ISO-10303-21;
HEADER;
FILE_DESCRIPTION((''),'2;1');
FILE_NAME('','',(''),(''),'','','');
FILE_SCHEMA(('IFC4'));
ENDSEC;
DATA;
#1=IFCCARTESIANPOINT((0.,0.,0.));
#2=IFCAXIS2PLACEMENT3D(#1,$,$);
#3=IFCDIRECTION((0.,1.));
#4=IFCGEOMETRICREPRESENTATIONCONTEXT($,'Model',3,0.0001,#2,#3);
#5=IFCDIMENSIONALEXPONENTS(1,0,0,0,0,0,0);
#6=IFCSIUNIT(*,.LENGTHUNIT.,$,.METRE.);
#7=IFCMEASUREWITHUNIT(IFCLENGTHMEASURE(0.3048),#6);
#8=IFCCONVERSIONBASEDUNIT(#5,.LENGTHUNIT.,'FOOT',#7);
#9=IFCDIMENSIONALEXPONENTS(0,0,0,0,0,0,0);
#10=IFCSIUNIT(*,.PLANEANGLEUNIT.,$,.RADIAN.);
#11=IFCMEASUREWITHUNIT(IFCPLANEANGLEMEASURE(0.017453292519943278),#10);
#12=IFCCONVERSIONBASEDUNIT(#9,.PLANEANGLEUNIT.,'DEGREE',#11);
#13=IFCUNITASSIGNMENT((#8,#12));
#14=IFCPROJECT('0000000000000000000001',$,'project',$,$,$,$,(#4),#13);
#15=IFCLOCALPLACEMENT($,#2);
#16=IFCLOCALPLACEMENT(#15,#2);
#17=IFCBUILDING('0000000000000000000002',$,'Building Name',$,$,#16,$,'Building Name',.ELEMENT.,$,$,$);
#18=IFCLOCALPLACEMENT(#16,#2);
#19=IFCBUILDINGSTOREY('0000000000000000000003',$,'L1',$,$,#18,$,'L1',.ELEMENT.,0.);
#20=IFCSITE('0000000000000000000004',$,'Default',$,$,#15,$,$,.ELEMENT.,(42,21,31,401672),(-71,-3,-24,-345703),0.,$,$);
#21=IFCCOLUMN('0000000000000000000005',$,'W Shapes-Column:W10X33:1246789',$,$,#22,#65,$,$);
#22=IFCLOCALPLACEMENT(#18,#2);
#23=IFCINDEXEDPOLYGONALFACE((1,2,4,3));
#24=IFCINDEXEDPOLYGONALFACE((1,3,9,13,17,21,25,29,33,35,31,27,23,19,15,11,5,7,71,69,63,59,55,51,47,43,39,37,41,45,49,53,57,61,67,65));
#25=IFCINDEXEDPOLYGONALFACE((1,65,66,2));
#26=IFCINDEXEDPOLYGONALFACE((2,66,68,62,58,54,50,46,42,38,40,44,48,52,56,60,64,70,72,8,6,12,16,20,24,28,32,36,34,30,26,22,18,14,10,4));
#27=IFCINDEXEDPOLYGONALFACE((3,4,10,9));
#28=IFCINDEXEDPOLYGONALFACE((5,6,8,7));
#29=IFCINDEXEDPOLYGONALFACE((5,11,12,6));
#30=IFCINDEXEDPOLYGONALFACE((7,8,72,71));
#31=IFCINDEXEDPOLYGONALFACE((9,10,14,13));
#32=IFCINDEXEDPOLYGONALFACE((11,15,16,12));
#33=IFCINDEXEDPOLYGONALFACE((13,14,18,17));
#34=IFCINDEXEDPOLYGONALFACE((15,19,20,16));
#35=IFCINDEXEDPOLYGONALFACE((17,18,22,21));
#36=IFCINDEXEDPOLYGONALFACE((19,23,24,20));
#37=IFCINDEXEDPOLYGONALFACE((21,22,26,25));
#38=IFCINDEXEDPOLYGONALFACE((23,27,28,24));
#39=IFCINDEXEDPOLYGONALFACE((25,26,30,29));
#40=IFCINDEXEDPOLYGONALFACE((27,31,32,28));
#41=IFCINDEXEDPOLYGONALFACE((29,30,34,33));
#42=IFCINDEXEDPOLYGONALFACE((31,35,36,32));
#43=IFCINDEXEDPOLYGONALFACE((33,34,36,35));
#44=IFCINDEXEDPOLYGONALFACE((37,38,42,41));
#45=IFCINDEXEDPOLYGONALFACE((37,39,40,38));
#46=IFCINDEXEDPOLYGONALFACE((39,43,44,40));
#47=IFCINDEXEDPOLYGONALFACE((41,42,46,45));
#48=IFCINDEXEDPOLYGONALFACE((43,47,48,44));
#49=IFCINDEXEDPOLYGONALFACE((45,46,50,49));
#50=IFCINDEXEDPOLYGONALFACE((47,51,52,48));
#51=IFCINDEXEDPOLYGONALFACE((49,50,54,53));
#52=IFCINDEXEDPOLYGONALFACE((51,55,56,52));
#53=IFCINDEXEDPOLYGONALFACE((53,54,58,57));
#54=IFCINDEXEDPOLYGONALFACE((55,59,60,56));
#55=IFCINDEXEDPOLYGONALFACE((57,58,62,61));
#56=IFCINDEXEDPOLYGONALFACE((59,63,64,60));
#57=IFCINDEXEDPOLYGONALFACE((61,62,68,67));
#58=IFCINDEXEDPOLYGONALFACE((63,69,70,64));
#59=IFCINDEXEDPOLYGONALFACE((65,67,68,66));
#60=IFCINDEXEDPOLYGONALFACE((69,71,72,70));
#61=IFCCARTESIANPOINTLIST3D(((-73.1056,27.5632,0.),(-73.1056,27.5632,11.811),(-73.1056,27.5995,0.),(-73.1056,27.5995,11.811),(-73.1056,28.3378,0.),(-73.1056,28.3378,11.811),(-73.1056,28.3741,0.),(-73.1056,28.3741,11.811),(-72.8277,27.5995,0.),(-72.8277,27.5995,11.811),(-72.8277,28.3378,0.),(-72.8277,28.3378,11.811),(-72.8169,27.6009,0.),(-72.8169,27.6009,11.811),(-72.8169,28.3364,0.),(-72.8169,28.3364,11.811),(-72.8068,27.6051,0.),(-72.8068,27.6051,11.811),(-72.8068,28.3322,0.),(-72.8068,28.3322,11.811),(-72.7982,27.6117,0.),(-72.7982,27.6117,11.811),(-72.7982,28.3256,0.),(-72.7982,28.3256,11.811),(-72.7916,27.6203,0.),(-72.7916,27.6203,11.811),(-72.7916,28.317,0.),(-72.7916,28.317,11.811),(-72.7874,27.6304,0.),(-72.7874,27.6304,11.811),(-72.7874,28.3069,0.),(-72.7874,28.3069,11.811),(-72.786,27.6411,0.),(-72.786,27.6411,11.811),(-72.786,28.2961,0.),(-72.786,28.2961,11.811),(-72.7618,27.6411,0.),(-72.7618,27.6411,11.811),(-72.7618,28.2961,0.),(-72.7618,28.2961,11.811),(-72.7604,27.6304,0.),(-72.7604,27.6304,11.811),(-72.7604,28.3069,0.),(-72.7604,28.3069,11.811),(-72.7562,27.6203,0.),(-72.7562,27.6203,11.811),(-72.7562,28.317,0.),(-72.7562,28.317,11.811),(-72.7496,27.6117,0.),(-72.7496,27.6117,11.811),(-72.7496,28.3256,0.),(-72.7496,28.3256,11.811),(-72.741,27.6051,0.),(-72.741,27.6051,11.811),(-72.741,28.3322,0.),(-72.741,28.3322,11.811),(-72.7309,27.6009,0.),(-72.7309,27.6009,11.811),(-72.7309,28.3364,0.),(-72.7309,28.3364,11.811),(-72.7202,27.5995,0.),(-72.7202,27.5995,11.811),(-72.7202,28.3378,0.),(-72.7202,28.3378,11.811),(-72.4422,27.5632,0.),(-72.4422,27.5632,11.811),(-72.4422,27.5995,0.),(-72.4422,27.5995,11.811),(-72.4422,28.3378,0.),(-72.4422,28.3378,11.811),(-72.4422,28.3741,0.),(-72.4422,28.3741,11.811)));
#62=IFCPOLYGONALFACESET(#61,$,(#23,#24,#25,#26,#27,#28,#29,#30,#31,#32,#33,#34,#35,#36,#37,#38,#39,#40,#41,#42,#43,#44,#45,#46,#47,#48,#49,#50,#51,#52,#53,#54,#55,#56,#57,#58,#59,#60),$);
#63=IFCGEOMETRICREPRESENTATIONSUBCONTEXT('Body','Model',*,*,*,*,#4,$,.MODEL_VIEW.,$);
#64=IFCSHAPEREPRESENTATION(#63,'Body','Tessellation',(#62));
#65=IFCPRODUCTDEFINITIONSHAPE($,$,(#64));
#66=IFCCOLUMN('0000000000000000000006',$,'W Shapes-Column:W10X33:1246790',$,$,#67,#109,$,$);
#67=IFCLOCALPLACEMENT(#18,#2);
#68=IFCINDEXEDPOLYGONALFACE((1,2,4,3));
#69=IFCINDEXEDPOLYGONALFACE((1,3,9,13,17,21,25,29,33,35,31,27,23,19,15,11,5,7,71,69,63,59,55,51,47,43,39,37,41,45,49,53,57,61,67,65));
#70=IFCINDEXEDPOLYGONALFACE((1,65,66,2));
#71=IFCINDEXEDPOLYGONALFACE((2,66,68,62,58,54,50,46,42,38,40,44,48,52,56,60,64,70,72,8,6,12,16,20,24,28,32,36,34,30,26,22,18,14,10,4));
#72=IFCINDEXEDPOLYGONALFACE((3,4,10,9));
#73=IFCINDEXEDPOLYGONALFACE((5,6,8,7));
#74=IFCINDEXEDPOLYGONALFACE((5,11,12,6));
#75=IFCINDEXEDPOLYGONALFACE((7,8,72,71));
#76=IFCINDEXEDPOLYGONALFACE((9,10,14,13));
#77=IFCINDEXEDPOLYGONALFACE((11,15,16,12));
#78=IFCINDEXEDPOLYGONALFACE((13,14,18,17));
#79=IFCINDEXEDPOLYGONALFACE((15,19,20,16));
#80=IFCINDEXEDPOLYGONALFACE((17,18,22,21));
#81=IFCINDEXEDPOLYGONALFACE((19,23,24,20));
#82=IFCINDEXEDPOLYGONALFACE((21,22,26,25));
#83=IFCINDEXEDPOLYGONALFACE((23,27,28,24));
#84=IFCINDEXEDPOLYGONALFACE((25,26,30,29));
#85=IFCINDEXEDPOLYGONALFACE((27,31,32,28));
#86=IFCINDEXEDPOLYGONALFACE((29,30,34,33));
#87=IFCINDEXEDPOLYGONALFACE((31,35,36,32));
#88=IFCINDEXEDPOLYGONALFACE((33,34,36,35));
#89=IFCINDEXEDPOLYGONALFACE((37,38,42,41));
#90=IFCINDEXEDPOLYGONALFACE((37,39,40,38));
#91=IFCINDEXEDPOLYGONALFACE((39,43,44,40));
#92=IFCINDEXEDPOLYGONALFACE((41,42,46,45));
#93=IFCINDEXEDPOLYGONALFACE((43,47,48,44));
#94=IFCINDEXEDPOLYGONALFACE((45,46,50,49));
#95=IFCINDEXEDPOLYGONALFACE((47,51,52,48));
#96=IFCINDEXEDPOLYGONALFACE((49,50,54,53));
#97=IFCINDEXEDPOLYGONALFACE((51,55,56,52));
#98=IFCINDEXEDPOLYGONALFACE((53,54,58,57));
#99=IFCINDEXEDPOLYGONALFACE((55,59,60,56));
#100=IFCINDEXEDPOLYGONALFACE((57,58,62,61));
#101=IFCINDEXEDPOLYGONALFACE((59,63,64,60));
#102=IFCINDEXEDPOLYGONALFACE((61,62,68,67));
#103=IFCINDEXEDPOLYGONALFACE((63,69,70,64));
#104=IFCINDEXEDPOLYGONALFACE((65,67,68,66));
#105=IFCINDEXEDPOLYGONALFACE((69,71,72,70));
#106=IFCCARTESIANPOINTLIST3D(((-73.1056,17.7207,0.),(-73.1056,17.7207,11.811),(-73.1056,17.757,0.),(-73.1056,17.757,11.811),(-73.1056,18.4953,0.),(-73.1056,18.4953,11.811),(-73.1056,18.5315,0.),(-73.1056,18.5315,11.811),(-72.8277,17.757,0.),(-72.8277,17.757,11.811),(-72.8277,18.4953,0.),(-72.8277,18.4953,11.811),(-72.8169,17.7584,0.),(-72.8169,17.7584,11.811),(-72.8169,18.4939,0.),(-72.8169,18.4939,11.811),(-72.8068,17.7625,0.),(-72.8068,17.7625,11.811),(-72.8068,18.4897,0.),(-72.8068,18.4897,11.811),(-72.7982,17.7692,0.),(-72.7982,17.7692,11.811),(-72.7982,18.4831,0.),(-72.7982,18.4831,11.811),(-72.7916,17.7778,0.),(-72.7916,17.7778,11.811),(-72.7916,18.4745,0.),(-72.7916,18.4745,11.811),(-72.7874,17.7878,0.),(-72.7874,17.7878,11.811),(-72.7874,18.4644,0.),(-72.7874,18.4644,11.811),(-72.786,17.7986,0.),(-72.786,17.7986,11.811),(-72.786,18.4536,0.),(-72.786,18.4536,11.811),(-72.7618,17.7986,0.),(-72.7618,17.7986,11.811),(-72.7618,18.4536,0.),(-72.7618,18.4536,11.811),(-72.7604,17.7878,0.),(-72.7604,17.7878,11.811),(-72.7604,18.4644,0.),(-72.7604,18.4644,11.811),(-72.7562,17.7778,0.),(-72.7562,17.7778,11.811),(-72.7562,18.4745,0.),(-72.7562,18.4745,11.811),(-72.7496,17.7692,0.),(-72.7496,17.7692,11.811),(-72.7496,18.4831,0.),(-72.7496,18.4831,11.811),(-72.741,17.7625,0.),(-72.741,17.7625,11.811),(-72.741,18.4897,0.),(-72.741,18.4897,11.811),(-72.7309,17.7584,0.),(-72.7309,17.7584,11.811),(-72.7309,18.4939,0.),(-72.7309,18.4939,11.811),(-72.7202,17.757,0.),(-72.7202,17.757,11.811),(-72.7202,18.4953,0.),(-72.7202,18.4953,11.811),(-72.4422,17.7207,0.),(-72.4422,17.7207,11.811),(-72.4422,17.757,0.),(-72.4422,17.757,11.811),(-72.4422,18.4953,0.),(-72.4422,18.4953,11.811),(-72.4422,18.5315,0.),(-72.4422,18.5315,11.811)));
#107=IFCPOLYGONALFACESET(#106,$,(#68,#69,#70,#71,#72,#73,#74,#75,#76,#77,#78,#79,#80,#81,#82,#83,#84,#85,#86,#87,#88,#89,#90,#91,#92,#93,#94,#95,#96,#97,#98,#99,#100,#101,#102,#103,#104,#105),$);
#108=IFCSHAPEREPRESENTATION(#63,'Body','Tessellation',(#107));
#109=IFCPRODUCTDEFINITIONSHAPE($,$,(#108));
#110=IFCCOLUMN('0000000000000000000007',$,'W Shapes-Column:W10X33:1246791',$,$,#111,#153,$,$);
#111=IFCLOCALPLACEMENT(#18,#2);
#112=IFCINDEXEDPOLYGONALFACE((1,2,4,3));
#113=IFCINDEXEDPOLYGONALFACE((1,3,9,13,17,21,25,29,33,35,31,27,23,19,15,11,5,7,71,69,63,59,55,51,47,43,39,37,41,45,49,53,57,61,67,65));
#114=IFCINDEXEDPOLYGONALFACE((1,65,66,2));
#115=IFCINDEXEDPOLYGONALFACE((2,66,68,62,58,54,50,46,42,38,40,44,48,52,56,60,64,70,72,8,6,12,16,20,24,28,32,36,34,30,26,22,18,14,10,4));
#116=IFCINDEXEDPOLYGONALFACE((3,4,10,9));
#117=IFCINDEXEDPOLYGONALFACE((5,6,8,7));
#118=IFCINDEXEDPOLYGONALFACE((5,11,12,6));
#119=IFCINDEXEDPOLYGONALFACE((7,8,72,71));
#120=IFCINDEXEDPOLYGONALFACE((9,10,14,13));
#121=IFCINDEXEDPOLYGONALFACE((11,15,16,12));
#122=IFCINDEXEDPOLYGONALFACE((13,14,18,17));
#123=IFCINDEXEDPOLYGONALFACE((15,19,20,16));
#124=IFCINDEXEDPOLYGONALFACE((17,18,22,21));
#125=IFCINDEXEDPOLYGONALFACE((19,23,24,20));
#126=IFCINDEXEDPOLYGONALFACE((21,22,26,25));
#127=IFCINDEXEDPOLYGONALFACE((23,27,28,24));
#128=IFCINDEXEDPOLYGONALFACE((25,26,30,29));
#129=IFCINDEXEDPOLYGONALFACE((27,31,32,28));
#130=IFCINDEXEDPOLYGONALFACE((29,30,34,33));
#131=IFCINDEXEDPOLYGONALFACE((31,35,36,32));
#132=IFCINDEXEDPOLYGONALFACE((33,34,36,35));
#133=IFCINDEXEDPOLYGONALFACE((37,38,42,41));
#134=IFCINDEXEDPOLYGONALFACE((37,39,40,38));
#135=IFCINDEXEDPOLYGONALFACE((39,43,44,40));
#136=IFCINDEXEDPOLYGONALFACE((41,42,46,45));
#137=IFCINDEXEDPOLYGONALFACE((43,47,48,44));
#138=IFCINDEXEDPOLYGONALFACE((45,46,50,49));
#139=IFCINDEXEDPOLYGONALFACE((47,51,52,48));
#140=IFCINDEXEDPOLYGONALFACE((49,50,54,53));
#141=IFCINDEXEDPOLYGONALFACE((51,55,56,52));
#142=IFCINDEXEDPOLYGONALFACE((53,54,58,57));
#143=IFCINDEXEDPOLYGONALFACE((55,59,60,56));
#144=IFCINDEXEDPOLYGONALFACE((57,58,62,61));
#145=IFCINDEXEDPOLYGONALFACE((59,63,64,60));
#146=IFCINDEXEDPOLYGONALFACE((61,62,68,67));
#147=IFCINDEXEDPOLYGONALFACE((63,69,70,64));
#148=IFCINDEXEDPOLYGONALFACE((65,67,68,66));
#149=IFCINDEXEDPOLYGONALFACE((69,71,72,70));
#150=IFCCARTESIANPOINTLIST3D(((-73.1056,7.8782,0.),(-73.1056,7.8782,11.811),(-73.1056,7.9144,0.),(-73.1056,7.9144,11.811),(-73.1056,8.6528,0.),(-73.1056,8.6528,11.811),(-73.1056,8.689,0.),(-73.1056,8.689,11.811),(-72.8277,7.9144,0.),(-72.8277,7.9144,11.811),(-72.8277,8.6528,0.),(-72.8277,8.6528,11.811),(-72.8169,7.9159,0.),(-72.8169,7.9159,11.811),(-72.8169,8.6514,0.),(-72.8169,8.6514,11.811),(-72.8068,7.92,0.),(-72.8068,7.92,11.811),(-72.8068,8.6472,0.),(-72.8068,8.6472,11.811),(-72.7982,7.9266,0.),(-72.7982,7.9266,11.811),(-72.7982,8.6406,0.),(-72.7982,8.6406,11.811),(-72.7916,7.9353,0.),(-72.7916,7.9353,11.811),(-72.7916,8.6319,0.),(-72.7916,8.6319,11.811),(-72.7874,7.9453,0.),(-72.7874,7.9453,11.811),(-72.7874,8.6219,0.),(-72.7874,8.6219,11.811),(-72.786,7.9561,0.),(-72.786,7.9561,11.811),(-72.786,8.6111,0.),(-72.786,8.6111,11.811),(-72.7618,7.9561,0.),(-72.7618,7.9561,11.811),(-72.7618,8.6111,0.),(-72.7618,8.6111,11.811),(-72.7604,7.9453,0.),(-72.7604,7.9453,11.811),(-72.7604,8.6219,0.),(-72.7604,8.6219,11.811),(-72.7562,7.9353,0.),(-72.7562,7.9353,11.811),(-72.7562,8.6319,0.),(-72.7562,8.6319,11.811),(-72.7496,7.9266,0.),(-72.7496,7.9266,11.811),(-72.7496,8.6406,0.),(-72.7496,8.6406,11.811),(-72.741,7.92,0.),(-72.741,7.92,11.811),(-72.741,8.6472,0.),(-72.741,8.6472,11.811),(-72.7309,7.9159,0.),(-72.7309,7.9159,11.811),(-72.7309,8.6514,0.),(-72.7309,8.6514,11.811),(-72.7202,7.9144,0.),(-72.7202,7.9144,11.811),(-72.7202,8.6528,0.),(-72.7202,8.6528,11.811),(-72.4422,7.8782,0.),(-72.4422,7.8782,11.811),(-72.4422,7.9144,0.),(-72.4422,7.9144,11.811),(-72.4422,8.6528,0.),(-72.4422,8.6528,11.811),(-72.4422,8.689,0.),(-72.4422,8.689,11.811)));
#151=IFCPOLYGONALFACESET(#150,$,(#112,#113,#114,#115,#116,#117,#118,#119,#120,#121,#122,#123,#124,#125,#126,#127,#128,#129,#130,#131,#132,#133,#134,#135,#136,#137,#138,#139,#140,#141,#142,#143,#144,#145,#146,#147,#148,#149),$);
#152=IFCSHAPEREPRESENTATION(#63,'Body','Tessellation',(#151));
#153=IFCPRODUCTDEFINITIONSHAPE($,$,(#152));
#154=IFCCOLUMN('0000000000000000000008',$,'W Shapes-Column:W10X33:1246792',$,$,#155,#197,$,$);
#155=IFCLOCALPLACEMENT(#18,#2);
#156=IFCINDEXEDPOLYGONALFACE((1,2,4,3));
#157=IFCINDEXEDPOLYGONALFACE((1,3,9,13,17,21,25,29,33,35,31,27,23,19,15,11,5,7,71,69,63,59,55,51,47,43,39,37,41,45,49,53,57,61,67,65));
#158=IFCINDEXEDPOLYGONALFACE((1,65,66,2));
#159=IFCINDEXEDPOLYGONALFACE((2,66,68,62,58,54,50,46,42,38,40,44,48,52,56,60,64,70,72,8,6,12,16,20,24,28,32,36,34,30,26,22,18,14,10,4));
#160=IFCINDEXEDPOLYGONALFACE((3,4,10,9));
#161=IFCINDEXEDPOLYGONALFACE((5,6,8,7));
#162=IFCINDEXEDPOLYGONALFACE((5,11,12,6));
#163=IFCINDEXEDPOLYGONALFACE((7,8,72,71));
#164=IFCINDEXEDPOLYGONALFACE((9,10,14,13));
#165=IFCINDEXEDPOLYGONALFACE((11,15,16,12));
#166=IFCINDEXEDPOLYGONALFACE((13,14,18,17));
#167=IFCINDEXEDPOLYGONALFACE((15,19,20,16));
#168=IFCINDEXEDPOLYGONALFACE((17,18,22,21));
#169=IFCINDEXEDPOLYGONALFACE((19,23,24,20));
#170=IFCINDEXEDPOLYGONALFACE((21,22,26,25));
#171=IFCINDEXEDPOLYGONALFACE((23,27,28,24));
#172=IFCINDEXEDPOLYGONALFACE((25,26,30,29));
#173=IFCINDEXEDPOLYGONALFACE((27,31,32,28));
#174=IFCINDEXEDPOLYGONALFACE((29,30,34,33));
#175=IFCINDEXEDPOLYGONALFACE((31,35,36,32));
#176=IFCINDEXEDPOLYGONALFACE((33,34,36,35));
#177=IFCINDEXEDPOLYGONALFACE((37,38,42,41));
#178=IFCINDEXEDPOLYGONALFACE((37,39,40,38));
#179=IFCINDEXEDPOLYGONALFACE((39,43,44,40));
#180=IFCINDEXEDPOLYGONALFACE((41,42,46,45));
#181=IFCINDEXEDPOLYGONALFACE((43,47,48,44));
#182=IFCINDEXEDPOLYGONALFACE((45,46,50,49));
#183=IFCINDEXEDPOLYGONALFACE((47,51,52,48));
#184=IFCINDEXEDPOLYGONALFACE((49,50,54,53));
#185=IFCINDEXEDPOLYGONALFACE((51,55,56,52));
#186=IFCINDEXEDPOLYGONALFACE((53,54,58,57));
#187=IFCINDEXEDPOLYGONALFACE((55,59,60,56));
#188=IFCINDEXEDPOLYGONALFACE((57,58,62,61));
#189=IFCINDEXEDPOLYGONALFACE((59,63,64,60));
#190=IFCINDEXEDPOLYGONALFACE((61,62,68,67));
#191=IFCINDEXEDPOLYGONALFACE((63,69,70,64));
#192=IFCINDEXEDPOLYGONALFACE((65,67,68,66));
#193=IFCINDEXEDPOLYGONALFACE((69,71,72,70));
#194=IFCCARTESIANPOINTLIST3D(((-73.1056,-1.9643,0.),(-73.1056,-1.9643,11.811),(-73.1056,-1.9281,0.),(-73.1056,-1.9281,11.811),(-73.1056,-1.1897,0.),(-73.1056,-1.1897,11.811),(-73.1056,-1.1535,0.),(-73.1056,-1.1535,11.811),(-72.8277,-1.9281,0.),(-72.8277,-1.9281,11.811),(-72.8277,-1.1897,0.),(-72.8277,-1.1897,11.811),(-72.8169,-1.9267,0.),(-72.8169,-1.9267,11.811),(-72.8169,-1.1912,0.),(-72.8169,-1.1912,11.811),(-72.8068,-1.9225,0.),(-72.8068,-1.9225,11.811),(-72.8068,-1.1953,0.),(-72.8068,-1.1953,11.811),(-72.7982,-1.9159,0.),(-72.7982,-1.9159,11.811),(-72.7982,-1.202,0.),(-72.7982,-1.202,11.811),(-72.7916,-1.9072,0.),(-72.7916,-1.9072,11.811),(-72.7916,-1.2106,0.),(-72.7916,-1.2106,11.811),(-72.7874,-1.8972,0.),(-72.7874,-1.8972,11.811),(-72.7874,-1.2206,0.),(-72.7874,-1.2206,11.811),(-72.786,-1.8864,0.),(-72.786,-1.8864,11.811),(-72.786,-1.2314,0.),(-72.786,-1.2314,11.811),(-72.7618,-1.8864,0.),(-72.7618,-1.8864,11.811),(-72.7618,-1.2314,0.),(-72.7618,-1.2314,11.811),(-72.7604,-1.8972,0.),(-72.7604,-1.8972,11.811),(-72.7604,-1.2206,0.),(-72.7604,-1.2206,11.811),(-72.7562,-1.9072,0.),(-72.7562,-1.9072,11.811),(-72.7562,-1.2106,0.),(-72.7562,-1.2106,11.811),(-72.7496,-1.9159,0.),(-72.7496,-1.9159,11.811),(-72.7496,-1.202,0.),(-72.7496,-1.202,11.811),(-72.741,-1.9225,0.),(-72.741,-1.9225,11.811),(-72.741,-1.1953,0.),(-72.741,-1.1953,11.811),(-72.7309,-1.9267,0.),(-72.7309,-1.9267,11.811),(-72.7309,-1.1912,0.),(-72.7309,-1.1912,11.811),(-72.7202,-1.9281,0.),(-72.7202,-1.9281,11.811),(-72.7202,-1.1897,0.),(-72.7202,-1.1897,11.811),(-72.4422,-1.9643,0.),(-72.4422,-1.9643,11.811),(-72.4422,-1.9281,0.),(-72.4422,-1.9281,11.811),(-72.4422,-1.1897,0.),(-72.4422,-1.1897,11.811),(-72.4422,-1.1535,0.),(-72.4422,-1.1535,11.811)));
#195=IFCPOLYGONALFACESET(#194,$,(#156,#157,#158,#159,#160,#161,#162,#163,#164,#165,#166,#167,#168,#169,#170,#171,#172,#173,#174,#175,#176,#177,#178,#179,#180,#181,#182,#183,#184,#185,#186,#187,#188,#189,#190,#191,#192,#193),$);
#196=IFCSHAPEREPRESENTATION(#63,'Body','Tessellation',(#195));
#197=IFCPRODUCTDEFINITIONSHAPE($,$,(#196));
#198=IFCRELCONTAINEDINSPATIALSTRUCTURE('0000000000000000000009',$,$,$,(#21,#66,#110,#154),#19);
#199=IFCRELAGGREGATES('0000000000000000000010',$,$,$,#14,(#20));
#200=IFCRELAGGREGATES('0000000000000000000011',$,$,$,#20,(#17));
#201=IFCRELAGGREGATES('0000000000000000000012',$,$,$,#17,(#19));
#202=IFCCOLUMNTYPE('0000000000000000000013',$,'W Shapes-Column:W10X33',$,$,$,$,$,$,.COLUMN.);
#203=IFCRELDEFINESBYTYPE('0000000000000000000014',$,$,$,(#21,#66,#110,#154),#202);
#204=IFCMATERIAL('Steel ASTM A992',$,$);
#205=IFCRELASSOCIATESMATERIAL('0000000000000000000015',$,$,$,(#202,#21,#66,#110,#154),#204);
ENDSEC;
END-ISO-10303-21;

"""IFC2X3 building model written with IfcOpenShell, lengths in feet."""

from ifc_helpers import new_model, entity, si_unit, converted_unit, direction, frame, frame_2d, origin, place, context, subcontext, project, spatial, i_section, extrude, source, transform, mapped, material, type_object, type_shapes, element, save


model = new_model("IFC2X3")

# Units and contexts
model_context = context("Model", 3, precision=0.0001, world=origin(), true_north=direction((0.0, 1.0)))
body_context = subcontext(model_context, "Body", "Model", "MODEL_VIEW")
ifc_project = project(units=[converted_unit("LENGTHUNIT", "FOOT", entity("IfcLengthMeasure", 0.3048), si_unit("LENGTHUNIT", "METRE"), dimensions=[1, 0, 0, 0, 0, 0, 0]), converted_unit("PLANEANGLEUNIT", "DEGREE", entity("IfcPlaneAngleMeasure", 0.017453292519943278), si_unit("PLANEANGLEUNIT", "RADIAN"), dimensions=[0, 0, 0, 0, 0, 0, 0])], contexts=[model_context])

# Site, building, storey
site_placement = place(None, origin())
site = spatial("IfcSite", under=ifc_project, at=site_placement, Name="Default", CompositionType="ELEMENT", RefLatitude=(42, 21, 31, 401672), RefLongitude=(-71, -3, -24, -345703), RefElevation=0.0)
building_placement = place(site_placement, origin())
building = spatial("IfcBuilding", under=site, at=building_placement, Name="Building Name", LongName="Building Name", CompositionType="ELEMENT")
storey_placement = place(building_placement, origin())
storey = spatial("IfcBuildingStorey", under=building, at=storey_placement, Name="L1", LongName="L1", CompositionType="ELEMENT", Elevation=0.0)

# Columns
ifc_material = material(Name="Steel ASTM A992")
column_type = type_object("IfcColumnType", Name="W Shapes-Column:W10X33", PredefinedType="COLUMN", material=ifc_material)
shared_shape = source(origin(), body_context, "Body", "SweptSolid", [
    extrude(i_section(OverallWidth=0.6633, OverallDepth=0.8108, WebThickness=0.0242, FlangeThickness=0.0362, FilletRadius=0.0417, at=frame_2d((0.0, 0.0), x_axis=(1.0, 0.0))), frame((0.0, 0.0, 0.0), z_axis=(0.0, 0.0, 1.0), x_axis=(-1.0, 0.0, 0.0)), (0.0, 0.0, 1.0), 11.811),
])
type_shapes(column_type, [shared_shape])
for number, where, name in (
    (1, (-72.7739, 27.9686, 0.0), "W Shapes-Column:W10X33:1246789"),
    (2, (-72.7739, 18.1261, 0.0), "W Shapes-Column:W10X33:1246790"),
    (3, (-72.7739, 8.2836, 0.0), "W Shapes-Column:W10X33:1246791"),
    (4, (-72.7739, -1.5589, 0.0), "W Shapes-Column:W10X33:1246792"),
):
    element("IfcColumn", number, at=place(storey_placement, frame(where)), inside=storey, type_object=column_type, material=ifc_material, Name=name, context=body_context, shape_type="MappedRepresentation", body=[
        mapped(shared_shape, transform((0.0, 0.0, 0.0), scale=1.0)),
    ])

save(model, "model.ifc")
